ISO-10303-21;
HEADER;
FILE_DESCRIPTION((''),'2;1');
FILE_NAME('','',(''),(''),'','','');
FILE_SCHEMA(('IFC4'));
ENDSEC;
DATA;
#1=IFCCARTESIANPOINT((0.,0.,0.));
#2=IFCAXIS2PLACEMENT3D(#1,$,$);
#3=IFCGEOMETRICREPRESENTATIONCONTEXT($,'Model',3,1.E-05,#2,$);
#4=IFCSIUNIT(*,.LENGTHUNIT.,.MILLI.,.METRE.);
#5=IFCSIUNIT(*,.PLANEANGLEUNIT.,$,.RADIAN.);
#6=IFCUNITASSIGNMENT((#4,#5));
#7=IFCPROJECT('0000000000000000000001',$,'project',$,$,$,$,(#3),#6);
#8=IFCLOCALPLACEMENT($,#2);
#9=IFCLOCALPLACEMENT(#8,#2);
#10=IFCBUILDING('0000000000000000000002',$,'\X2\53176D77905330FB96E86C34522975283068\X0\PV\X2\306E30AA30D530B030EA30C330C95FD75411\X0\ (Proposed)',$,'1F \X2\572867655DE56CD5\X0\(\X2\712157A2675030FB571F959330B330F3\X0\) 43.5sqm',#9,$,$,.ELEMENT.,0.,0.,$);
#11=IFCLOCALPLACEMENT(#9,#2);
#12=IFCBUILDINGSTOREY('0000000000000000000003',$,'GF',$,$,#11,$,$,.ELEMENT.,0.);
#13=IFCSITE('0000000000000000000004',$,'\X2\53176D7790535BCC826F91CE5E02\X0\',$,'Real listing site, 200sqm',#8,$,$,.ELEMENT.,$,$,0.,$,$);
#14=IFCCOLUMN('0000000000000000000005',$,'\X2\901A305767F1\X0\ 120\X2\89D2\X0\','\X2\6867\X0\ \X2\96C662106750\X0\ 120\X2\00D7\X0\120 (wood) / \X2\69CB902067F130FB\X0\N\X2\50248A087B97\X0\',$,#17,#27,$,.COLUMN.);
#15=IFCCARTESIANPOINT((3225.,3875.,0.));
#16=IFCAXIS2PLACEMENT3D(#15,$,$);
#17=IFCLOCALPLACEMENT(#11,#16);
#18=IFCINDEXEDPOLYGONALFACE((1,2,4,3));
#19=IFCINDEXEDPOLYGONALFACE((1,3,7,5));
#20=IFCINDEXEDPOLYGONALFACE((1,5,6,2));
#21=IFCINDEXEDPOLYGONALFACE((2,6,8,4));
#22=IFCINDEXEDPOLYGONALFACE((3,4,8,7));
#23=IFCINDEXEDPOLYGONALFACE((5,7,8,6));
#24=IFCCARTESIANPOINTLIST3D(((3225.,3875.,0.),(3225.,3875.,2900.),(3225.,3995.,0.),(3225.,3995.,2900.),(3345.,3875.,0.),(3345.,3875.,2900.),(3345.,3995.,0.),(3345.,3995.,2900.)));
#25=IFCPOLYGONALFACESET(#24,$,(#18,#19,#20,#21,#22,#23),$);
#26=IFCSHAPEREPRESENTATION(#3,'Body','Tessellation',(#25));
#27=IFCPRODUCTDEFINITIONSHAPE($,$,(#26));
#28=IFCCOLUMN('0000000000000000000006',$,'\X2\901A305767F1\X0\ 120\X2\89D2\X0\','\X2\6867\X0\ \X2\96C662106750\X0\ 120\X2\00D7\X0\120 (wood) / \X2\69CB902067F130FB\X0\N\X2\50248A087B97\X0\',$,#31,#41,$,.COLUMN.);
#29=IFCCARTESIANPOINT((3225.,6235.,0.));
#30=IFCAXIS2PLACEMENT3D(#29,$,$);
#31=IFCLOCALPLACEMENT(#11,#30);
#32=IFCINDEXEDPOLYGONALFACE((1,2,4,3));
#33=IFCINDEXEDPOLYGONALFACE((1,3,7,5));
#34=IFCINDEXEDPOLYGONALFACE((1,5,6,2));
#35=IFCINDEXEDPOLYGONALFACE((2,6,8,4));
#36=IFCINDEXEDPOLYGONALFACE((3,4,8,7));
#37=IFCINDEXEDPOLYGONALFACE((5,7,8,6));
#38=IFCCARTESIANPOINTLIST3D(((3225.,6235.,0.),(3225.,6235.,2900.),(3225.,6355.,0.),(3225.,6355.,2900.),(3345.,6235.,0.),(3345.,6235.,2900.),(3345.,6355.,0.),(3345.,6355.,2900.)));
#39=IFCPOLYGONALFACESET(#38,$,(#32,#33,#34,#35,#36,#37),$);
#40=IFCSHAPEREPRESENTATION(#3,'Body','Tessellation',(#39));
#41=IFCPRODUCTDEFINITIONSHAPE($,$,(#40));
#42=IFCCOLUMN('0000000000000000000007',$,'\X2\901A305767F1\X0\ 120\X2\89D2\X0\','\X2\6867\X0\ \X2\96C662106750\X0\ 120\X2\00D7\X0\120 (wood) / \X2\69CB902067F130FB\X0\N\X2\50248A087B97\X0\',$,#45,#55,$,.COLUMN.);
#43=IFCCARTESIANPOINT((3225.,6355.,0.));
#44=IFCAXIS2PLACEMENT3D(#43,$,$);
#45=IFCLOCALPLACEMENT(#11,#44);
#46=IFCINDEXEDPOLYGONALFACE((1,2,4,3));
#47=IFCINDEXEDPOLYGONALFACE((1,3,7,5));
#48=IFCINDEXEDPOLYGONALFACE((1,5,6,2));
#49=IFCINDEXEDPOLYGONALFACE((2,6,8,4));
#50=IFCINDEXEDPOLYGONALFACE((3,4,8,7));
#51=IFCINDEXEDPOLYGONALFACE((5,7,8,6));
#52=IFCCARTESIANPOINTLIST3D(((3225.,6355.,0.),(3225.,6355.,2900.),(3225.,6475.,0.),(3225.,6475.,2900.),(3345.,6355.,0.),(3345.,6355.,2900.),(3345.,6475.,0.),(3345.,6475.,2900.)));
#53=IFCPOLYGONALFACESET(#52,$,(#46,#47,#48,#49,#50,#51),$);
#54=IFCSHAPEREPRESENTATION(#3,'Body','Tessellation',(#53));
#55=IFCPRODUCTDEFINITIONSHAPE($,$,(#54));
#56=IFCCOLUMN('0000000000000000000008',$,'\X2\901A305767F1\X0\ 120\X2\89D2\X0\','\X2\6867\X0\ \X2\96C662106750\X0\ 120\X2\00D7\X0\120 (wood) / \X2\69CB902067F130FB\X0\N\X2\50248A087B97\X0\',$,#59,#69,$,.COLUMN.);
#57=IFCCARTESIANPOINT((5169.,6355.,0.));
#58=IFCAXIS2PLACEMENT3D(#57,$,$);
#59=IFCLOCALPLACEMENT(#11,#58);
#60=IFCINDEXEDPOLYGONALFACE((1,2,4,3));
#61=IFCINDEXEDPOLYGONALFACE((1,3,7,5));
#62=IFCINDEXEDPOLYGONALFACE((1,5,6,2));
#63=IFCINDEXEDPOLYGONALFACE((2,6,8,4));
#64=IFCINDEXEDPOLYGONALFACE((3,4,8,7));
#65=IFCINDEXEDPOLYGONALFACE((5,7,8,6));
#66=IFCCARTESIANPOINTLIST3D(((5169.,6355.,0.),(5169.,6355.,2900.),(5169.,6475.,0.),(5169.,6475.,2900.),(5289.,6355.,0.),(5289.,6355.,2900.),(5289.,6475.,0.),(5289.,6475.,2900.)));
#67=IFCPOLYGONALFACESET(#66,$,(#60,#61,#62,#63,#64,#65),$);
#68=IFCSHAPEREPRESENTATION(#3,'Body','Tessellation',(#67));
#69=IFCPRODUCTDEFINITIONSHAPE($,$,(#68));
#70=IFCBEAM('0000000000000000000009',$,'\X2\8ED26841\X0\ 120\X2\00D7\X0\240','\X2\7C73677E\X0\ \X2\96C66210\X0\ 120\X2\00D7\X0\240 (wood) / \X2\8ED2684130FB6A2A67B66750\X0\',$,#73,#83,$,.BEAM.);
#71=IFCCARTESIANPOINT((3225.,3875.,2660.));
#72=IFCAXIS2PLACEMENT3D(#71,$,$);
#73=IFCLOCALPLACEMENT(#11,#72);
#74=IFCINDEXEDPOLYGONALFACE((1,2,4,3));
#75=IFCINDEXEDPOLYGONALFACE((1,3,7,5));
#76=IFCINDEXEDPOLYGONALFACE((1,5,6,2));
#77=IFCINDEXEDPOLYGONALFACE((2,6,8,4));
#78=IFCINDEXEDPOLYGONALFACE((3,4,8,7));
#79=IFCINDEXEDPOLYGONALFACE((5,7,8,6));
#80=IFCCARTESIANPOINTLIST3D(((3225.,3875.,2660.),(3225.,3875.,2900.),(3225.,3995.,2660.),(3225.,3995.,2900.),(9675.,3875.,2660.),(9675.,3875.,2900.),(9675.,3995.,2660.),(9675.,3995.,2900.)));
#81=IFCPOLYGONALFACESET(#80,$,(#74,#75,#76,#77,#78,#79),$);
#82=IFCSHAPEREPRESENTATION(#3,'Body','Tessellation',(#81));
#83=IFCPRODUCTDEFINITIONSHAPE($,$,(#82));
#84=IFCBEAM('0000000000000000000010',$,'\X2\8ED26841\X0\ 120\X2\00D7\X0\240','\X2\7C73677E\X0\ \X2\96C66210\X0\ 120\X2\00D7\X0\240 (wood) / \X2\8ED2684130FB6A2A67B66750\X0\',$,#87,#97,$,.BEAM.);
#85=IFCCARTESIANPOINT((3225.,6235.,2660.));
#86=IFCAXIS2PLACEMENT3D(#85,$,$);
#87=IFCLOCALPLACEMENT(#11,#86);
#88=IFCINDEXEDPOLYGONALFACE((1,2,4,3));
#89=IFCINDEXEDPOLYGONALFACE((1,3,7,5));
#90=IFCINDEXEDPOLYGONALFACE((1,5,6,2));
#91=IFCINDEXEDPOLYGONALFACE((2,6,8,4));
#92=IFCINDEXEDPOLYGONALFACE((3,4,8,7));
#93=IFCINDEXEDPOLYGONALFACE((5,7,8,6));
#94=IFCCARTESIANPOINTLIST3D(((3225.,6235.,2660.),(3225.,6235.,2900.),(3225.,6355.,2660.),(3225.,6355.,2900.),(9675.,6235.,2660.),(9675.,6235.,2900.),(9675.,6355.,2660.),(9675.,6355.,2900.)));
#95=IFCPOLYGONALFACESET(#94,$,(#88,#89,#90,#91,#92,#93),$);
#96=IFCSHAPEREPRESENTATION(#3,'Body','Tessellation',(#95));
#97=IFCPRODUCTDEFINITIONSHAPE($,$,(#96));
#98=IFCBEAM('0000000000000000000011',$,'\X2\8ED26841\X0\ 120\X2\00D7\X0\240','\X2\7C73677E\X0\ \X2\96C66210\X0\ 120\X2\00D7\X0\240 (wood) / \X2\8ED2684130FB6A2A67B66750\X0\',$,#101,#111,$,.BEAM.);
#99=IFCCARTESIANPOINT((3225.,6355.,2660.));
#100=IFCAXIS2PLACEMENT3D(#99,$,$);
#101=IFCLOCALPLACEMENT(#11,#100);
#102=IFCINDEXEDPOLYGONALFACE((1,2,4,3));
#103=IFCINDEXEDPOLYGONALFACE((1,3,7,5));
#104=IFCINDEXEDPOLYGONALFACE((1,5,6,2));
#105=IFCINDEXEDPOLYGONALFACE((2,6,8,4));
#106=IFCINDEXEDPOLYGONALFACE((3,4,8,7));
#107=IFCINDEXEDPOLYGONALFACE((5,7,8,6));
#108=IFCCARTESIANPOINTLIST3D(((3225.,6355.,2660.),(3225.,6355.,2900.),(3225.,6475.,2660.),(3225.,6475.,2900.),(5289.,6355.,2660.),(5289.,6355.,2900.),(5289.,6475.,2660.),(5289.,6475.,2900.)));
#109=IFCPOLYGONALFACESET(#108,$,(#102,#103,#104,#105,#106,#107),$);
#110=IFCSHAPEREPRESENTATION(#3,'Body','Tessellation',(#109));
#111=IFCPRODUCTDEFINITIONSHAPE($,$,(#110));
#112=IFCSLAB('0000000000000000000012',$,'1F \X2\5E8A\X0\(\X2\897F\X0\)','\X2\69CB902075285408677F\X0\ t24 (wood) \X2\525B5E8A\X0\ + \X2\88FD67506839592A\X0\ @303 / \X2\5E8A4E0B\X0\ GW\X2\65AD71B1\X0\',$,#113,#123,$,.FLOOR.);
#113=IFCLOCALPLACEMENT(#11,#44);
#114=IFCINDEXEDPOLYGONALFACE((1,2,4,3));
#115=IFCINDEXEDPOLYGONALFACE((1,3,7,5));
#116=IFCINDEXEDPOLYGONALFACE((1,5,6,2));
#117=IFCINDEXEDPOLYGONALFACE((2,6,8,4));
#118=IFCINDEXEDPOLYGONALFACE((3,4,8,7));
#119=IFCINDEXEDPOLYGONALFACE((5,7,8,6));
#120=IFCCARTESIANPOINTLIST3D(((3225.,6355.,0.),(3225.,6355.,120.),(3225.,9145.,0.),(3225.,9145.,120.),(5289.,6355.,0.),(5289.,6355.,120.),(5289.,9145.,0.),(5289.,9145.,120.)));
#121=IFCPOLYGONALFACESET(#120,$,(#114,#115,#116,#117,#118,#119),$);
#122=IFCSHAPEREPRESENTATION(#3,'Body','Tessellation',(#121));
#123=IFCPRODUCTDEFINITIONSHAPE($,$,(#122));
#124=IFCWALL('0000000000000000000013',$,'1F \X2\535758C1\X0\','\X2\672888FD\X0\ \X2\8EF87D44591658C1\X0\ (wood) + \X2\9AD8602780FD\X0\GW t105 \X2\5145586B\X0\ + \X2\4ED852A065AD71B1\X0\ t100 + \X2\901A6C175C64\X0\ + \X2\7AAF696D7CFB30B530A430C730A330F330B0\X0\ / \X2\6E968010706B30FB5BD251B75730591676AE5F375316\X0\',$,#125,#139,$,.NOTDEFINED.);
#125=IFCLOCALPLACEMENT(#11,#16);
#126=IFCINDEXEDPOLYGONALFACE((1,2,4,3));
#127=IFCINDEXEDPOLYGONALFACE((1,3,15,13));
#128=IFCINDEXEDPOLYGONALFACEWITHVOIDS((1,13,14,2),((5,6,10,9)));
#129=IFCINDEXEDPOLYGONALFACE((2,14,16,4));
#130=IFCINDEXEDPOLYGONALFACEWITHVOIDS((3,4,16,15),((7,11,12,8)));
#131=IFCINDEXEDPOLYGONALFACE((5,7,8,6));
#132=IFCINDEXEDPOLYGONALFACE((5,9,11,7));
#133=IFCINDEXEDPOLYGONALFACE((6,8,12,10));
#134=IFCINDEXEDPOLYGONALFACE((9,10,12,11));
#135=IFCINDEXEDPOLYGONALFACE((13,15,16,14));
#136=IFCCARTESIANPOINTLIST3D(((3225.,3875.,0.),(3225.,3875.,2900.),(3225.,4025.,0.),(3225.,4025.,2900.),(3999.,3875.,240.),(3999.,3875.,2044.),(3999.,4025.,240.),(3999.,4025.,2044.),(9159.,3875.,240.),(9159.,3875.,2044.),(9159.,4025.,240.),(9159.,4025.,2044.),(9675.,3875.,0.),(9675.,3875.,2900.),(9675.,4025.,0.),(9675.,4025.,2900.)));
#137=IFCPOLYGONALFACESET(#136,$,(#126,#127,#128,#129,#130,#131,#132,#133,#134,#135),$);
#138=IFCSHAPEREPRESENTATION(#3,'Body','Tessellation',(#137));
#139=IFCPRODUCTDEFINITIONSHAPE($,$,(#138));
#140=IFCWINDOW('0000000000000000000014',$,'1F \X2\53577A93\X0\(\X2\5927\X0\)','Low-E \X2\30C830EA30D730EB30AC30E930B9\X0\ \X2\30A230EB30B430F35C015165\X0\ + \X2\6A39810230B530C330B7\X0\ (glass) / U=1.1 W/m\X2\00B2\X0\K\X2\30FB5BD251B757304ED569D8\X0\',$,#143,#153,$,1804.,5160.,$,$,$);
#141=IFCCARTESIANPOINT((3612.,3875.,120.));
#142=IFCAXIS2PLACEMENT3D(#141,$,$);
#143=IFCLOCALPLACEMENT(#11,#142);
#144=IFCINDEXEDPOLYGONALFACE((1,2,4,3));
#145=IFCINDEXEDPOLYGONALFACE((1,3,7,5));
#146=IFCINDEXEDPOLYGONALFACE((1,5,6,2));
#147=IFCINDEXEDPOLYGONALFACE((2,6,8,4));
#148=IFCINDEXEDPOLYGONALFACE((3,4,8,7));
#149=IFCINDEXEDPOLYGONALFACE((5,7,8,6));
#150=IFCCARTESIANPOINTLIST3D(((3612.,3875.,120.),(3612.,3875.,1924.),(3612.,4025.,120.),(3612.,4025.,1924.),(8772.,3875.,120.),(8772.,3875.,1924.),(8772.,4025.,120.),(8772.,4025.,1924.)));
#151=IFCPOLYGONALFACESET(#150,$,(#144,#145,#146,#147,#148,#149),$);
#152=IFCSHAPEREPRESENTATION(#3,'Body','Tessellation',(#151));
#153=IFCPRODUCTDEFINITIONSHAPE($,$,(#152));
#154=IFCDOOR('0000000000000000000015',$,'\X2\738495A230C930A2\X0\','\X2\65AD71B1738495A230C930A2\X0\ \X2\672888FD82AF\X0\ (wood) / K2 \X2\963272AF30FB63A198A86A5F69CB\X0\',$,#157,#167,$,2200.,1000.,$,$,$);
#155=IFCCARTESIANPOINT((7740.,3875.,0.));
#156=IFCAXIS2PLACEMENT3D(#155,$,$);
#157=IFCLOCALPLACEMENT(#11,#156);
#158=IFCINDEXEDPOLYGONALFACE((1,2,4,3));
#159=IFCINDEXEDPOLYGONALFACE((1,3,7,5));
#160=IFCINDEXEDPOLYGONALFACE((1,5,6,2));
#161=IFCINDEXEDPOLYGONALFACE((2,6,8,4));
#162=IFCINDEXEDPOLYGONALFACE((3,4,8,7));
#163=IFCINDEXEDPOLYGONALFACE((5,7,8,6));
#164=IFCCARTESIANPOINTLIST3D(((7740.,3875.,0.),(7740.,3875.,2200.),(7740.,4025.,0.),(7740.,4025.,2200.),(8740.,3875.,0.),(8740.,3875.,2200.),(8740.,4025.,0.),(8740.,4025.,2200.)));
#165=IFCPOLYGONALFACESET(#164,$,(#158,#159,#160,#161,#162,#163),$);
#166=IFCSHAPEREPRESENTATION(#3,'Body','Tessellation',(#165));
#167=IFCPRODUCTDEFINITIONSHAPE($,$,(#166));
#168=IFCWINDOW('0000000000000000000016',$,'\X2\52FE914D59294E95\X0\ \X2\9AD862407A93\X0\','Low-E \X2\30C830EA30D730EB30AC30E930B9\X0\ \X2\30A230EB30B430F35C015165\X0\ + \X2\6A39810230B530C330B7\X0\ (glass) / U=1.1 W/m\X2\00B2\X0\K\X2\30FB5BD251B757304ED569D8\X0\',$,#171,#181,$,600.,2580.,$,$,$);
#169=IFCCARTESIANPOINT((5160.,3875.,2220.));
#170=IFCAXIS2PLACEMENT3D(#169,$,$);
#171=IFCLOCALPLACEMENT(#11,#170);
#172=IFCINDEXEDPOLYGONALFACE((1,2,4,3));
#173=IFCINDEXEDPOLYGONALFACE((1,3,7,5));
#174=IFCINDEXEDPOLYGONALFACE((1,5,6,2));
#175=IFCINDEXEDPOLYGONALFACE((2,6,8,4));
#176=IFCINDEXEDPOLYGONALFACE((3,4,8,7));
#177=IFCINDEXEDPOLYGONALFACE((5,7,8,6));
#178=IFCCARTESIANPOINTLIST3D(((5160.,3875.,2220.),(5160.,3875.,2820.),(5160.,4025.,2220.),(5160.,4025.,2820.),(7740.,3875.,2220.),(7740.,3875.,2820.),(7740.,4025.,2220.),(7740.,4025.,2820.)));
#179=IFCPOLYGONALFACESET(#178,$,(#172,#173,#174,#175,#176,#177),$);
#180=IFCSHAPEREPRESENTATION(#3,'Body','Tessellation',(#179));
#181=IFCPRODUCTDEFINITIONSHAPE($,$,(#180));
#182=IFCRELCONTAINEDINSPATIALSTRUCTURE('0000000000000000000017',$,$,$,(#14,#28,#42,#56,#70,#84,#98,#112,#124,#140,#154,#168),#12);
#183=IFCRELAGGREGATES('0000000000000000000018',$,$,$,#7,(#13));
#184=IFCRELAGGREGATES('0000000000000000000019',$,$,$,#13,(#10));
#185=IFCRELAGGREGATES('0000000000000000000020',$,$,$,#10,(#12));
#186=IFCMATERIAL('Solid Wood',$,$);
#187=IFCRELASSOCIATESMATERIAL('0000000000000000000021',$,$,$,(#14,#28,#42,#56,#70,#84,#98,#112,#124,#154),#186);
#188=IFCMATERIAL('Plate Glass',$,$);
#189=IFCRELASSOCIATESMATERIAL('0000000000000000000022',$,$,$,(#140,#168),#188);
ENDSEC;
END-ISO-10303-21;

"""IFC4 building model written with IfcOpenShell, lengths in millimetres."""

from ifc_helpers import new_model, si_unit, frame, frame_2d, origin, place, context, project, spatial, rectangle, extrude, material, element, fill, save


model = new_model("IFC4")

# Units and contexts
model_context = context("Model", 3, precision=1e-05, world=origin())
ifc_project = project(units=[si_unit("LENGTHUNIT", "METRE", prefix="MILLI"), si_unit("PLANEANGLEUNIT", "RADIAN")], contexts=[model_context])

# Site, building, storey
site_placement = place(None, origin())
site = spatial("IfcSite", under=ifc_project, at=site_placement, Name="北海道富良野市", ObjectType="Real listing site, 200sqm", CompositionType="ELEMENT", RefElevation=0.0)
building_placement = place(site_placement, origin())
building = spatial("IfcBuilding", under=site, at=building_placement, Name="北海道・雨水利用とPVのオフグリッド志向 (Proposed)", ObjectType="1F 在来工法(無垢材・土間コン) 43.5sqm", CompositionType="ELEMENT", ElevationOfRefHeight=0.0, ElevationOfTerrain=0.0)
storey_placement = place(building_placement, origin())
storey = spatial("IfcBuildingStorey", under=building, at=storey_placement, Name="GF", CompositionType="ELEMENT", Elevation=0.0)

# Columns
ifc_material_1 = material(Name="Solid Wood")
column_1_placement = place(storey_placement, frame((3225.0, 3875.0, 0.0)))
element("IfcColumn", 1, at=column_1_placement, inside=storey, material=ifc_material_1, Name="通し柱 120角", Description="桧 集成材 120×120 (wood) / 構造柱・N値計算", PredefinedType="COLUMN", context=model_context, shape_type="SweptSolid", body=[
    extrude(rectangle(XDim=120.0, YDim=120.0, at=frame_2d((60.0, 60.0))), frame((3225.0, 3875.0, 0.0)), (0.0, 0.0, 1.0), 2900.0),
])
column_2_placement = place(storey_placement, frame((3225.0, 6235.0, 0.0)))
element("IfcColumn", 2, at=column_2_placement, inside=storey, material=ifc_material_1, Name="通し柱 120角", Description="桧 集成材 120×120 (wood) / 構造柱・N値計算", PredefinedType="COLUMN", context=model_context, shape_type="SweptSolid", body=[
    extrude(rectangle(XDim=120.0, YDim=120.0, at=frame_2d((60.0, 60.0))), frame((3225.0, 6235.0, 0.0)), (0.0, 0.0, 1.0), 2900.0),
])
column_3_placement = place(storey_placement, frame((3225.0, 6355.0, 0.0)))
element("IfcColumn", 3, at=column_3_placement, inside=storey, material=ifc_material_1, Name="通し柱 120角", Description="桧 集成材 120×120 (wood) / 構造柱・N値計算", PredefinedType="COLUMN", context=model_context, shape_type="SweptSolid", body=[
    extrude(rectangle(XDim=120.0, YDim=120.0, at=frame_2d((60.0, 60.0))), frame((3225.0, 6355.0, 0.0)), (0.0, 0.0, 1.0), 2900.0),
])
column_4_placement = place(storey_placement, frame((5169.0, 6355.0, 0.0)))
element("IfcColumn", 4, at=column_4_placement, inside=storey, material=ifc_material_1, Name="通し柱 120角", Description="桧 集成材 120×120 (wood) / 構造柱・N値計算", PredefinedType="COLUMN", context=model_context, shape_type="SweptSolid", body=[
    extrude(rectangle(XDim=120.0, YDim=120.0, at=frame_2d((60.0, 60.0))), frame((5169.0, 6355.0, 0.0)), (0.0, 0.0, 1.0), 2900.0),
])

# Beams
beam_1_placement = place(storey_placement, frame((3225.0, 3875.0, 2660.0)))
element("IfcBeam", 5, at=beam_1_placement, inside=storey, material=ifc_material_1, Name="軒桁 120×240", Description="米松 集成 120×240 (wood) / 軒桁・横架材", PredefinedType="BEAM", context=model_context, shape_type="SweptSolid", body=[
    extrude(rectangle(XDim=6450.0, YDim=120.0, at=frame_2d((3225.0, 60.0))), frame((3225.0, 3875.0, 2660.0)), (0.0, 0.0, 1.0), 240.0),
])
beam_2_placement = place(storey_placement, frame((3225.0, 6235.0, 2660.0)))
element("IfcBeam", 6, at=beam_2_placement, inside=storey, material=ifc_material_1, Name="軒桁 120×240", Description="米松 集成 120×240 (wood) / 軒桁・横架材", PredefinedType="BEAM", context=model_context, shape_type="SweptSolid", body=[
    extrude(rectangle(XDim=6450.0, YDim=120.0, at=frame_2d((3225.0, 60.0))), frame((3225.0, 6235.0, 2660.0)), (0.0, 0.0, 1.0), 240.0),
])
beam_3_placement = place(storey_placement, frame((3225.0, 6355.0, 2660.0)))
element("IfcBeam", 7, at=beam_3_placement, inside=storey, material=ifc_material_1, Name="軒桁 120×240", Description="米松 集成 120×240 (wood) / 軒桁・横架材", PredefinedType="BEAM", context=model_context, shape_type="SweptSolid", body=[
    extrude(rectangle(XDim=2064.0, YDim=120.0, at=frame_2d((1032.0, 60.0))), frame((3225.0, 6355.0, 2660.0)), (0.0, 0.0, 1.0), 240.0),
])

# Slab
slab_1_placement = place(storey_placement, frame((3225.0, 6355.0, 0.0)))
element("IfcSlab", 8, at=slab_1_placement, inside=storey, material=ifc_material_1, Name="1F 床(西)", Description="構造用合板 t24 (wood) 剛床 + 製材根太 @303 / 床下 GW断熱", PredefinedType="FLOOR", context=model_context, shape_type="SweptSolid", body=[
    extrude(rectangle(XDim=2064.0, YDim=2790.0, at=frame_2d((1032.0, 1395.0))), frame((3225.0, 6355.0, 0.0)), (0.0, 0.0, 1.0), 120.0),
])

# Wall, openings, windows, door
wall_1_placement = place(storey_placement, frame((3225.0, 3875.0, 0.0)))
wall_1 = element("IfcWall", 9, at=wall_1_placement, inside=storey, material=ifc_material_1, Name="1F 南壁", Description="木製 軸組外壁 (wood) + 高性能GW t105 充填 + 付加断熱 t100 + 通気層 + 窯業系サイディング / 準耐火・寒冷地外皮強化", PredefinedType="NOTDEFINED", context=model_context, shape_type="SweptSolid", body=[
    extrude(rectangle(XDim=6450.0, YDim=150.0, at=frame_2d((3225.0, 75.0))), frame((3225.0, 3875.0, 0.0)), (0.0, 0.0, 1.0), 2900.0),
])
opening_1_placement = place(storey_placement, frame((3612.0, 3875.0, 120.0)))
opening_1 = element("IfcOpeningElement", 10, at=opening_1_placement, cuts=wall_1, PredefinedType="NOTDEFINED", context=model_context, shape_type="SweptSolid", body=[
    extrude(rectangle(XDim=5160.0, YDim=150.0, at=frame_2d((2580.0, 75.0))), frame((3612.0, 3875.0, 120.0)), (0.0, 0.0, 1.0), 1804.0),
])
opening_2_placement = place(storey_placement, frame((7740.0, 3875.0, 0.0)))
opening_2 = element("IfcOpeningElement", 11, at=opening_2_placement, cuts=wall_1, PredefinedType="NOTDEFINED", context=model_context, shape_type="SweptSolid", body=[
    extrude(rectangle(XDim=1000.0, YDim=150.0, at=frame_2d((500.0, 75.0))), frame((7740.0, 3875.0, 0.0)), (0.0, 0.0, 1.0), 2200.0),
])
opening_3_placement = place(storey_placement, frame((5160.0, 3875.0, 2220.0)))
opening_3 = element("IfcOpeningElement", 12, at=opening_3_placement, cuts=wall_1, PredefinedType="NOTDEFINED", context=model_context, shape_type="SweptSolid", body=[
    extrude(rectangle(XDim=2580.0, YDim=150.0, at=frame_2d((1290.0, 75.0))), frame((5160.0, 3875.0, 2220.0)), (0.0, 0.0, 1.0), 600.0),
])
ifc_material_2 = material(Name="Plate Glass")
window_1_placement = place(storey_placement, frame((3612.0, 3875.0, 120.0)))
window_1 = element("IfcWindow", 13, at=window_1_placement, inside=storey, material=ifc_material_2, Name="1F 南窓(大)", Description="Low-E トリプルガラス アルゴン封入 + 樹脂サッシ (glass) / U=1.1 W/m²K・寒冷地仕様", OverallHeight=1804.0, OverallWidth=5160.0, context=model_context, shape_type="SweptSolid", body=[
    extrude(rectangle(XDim=5160.0, YDim=150.0, at=frame_2d((2580.0, 75.0))), frame((3612.0, 3875.0, 120.0)), (0.0, 0.0, 1.0), 1804.0),
])
fill(opening_1, window_1)
door_placement = place(storey_placement, frame((7740.0, 3875.0, 0.0)))
door = element("IfcDoor", 14, at=door_placement, inside=storey, material=ifc_material_1, Name="玄関ドア", Description="断熱玄関ドア 木製芯 (wood) / K2 防犯・採風機構", OverallHeight=2200.0, OverallWidth=1000.0, context=model_context, shape_type="SweptSolid", body=[
    extrude(rectangle(XDim=1000.0, YDim=150.0, at=frame_2d((500.0, 75.0))), frame((7740.0, 3875.0, 0.0)), (0.0, 0.0, 1.0), 2200.0),
])
fill(opening_2, door)
window_2_placement = place(storey_placement, frame((5160.0, 3875.0, 2220.0)))
window_2 = element("IfcWindow", 15, at=window_2_placement, inside=storey, material=ifc_material_2, Name="勾配天井 高所窓", Description="Low-E トリプルガラス アルゴン封入 + 樹脂サッシ (glass) / U=1.1 W/m²K・寒冷地仕様", OverallHeight=600.0, OverallWidth=2580.0, context=model_context, shape_type="SweptSolid", body=[
    extrude(rectangle(XDim=2580.0, YDim=150.0, at=frame_2d((1290.0, 75.0))), frame((5160.0, 3875.0, 2220.0)), (0.0, 0.0, 1.0), 600.0),
])
fill(opening_3, window_2)

save(model, "model.ifc")
